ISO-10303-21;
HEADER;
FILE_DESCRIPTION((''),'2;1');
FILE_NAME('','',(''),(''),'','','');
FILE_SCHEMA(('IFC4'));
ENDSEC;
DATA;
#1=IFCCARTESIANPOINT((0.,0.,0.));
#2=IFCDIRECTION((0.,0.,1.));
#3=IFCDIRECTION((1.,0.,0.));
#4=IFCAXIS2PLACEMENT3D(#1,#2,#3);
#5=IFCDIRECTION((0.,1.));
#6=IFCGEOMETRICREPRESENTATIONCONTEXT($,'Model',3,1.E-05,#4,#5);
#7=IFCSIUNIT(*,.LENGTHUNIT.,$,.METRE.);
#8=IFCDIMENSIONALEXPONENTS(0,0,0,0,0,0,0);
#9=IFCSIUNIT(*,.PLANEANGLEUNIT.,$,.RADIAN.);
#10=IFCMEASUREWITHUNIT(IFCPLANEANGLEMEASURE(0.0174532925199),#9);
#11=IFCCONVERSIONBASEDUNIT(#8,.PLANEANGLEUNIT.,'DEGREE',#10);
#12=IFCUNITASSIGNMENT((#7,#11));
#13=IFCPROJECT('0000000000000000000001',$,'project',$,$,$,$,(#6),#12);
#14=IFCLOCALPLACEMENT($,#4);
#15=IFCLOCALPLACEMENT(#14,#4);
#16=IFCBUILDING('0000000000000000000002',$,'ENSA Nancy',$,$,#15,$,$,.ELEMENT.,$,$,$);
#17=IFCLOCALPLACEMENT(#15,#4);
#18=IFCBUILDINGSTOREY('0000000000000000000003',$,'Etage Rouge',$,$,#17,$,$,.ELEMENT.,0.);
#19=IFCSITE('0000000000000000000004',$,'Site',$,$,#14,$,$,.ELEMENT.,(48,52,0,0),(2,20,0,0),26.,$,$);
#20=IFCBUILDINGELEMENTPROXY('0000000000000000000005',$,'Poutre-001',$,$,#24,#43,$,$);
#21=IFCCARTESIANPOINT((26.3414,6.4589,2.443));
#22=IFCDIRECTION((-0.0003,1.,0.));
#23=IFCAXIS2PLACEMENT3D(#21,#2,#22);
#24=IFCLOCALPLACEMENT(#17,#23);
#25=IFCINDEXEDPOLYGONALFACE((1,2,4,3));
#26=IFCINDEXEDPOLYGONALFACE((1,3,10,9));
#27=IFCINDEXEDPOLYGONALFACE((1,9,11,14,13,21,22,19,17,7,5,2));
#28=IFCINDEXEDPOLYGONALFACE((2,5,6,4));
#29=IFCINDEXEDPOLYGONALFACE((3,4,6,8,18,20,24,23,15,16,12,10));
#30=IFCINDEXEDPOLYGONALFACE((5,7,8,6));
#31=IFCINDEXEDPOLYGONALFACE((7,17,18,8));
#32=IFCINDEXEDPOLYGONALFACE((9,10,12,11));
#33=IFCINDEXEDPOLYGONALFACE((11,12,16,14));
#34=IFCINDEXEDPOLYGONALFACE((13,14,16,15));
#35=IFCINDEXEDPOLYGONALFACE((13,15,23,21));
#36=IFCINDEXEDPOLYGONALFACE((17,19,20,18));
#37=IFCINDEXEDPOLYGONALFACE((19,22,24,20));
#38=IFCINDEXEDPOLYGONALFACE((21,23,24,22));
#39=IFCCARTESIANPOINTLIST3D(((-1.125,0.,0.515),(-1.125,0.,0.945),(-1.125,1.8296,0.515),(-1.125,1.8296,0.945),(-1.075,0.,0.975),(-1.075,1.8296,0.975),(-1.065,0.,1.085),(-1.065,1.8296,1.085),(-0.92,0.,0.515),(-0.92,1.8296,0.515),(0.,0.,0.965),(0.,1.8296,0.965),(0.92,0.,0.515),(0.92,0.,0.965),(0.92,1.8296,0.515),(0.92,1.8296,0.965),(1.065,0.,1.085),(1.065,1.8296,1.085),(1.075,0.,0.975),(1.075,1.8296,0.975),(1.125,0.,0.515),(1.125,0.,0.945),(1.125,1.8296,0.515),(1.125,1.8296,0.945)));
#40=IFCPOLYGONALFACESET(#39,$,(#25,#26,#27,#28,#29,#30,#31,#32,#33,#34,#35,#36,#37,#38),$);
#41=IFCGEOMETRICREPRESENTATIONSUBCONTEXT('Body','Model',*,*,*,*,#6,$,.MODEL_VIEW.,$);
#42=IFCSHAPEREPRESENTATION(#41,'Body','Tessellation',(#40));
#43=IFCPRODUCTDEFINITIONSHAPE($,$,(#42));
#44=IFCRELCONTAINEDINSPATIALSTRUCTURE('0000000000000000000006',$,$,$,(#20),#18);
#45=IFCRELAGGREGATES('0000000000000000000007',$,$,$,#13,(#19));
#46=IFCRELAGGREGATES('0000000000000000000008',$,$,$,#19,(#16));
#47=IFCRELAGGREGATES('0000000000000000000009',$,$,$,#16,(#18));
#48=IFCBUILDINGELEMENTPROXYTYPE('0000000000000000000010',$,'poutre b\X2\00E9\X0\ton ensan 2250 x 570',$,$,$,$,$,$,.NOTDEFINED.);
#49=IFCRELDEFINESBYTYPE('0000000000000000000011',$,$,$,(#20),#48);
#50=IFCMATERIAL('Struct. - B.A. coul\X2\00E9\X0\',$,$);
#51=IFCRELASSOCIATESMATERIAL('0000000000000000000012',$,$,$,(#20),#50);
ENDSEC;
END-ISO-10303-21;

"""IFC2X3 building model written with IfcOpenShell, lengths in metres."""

from ifc_helpers import new_model, entity, si_unit, converted_unit, direction, frame, origin_with_axes, place, context, subcontext, project, spatial, polyline, outline, extrude, material, type_object, element, save


model = new_model("IFC2X3")

# Units and contexts
model_context = context("Model", 3, precision=1e-05, world=origin_with_axes(), true_north=direction((0.0, 1.0)))
body_context = subcontext(model_context, "Body", "Model", "MODEL_VIEW")
ifc_project = project(units=[si_unit("LENGTHUNIT", "METRE"), converted_unit("PLANEANGLEUNIT", "DEGREE", entity("IfcPlaneAngleMeasure", 0.0174532925199), si_unit("PLANEANGLEUNIT", "RADIAN"), dimensions=[0, 0, 0, 0, 0, 0, 0])], contexts=[model_context])

# Site, building, storey
site_placement = place(None, origin_with_axes())
site = spatial("IfcSite", under=ifc_project, at=site_placement, Name="Site", CompositionType="ELEMENT", RefLatitude=(48, 52, 0, 0), RefLongitude=(2, 20, 0, 0), RefElevation=26.0)
building_placement = place(site_placement, origin_with_axes())
building = spatial("IfcBuilding", under=site, at=building_placement, Name="ENSA Nancy", CompositionType="ELEMENT")
storey_placement = place(building_placement, origin_with_axes())
storey = spatial("IfcBuildingStorey", under=building, at=storey_placement, Name="Etage Rouge", CompositionType="ELEMENT", Elevation=0.0)

# Building element proxy
ifc_material_1 = material(Name="Struct. - B.A. coulé")
building_element_proxy_type_1 = type_object("IfcBuildingElementProxyType", Name="poutre béton ensan 2250 x 570", PredefinedType="NOTDEFINED")
for number, where, z_axis, x_axis, name in (
    (1, (26.3414, 6.4589, 2.443), (0.0, 0.0, 1.0), (-0.0003, 1.0, 0.0), "Poutre-001"),
):
    element("IfcBuildingElementProxy", number, at=place(storey_placement, frame(where, z_axis=z_axis, x_axis=x_axis)), inside=storey, type_object=building_element_proxy_type_1, material=ifc_material_1, Name=name, context=body_context, shape_type="SweptSolid", body=[
        extrude(outline(polyline([(-1.065, 1.085), (-1.075, 0.975), (-1.125, 0.945), (-1.125, 0.515), (-0.92, 0.515), (0.0, 0.965), (0.92, 0.965), (0.92, 0.515), (1.125, 0.515), (1.125, 0.945), (1.075, 0.975), (1.065, 1.085), (-1.065, 1.085)])), frame((0.0, 1.8296, 0.0), z_axis=(0.0, -1.0, 0.0), x_axis=(1.0, 0.0, 0.0)), (0.0, 0.0, 1.0), 1.8296),
    ])

save(model, "model.ifc")
